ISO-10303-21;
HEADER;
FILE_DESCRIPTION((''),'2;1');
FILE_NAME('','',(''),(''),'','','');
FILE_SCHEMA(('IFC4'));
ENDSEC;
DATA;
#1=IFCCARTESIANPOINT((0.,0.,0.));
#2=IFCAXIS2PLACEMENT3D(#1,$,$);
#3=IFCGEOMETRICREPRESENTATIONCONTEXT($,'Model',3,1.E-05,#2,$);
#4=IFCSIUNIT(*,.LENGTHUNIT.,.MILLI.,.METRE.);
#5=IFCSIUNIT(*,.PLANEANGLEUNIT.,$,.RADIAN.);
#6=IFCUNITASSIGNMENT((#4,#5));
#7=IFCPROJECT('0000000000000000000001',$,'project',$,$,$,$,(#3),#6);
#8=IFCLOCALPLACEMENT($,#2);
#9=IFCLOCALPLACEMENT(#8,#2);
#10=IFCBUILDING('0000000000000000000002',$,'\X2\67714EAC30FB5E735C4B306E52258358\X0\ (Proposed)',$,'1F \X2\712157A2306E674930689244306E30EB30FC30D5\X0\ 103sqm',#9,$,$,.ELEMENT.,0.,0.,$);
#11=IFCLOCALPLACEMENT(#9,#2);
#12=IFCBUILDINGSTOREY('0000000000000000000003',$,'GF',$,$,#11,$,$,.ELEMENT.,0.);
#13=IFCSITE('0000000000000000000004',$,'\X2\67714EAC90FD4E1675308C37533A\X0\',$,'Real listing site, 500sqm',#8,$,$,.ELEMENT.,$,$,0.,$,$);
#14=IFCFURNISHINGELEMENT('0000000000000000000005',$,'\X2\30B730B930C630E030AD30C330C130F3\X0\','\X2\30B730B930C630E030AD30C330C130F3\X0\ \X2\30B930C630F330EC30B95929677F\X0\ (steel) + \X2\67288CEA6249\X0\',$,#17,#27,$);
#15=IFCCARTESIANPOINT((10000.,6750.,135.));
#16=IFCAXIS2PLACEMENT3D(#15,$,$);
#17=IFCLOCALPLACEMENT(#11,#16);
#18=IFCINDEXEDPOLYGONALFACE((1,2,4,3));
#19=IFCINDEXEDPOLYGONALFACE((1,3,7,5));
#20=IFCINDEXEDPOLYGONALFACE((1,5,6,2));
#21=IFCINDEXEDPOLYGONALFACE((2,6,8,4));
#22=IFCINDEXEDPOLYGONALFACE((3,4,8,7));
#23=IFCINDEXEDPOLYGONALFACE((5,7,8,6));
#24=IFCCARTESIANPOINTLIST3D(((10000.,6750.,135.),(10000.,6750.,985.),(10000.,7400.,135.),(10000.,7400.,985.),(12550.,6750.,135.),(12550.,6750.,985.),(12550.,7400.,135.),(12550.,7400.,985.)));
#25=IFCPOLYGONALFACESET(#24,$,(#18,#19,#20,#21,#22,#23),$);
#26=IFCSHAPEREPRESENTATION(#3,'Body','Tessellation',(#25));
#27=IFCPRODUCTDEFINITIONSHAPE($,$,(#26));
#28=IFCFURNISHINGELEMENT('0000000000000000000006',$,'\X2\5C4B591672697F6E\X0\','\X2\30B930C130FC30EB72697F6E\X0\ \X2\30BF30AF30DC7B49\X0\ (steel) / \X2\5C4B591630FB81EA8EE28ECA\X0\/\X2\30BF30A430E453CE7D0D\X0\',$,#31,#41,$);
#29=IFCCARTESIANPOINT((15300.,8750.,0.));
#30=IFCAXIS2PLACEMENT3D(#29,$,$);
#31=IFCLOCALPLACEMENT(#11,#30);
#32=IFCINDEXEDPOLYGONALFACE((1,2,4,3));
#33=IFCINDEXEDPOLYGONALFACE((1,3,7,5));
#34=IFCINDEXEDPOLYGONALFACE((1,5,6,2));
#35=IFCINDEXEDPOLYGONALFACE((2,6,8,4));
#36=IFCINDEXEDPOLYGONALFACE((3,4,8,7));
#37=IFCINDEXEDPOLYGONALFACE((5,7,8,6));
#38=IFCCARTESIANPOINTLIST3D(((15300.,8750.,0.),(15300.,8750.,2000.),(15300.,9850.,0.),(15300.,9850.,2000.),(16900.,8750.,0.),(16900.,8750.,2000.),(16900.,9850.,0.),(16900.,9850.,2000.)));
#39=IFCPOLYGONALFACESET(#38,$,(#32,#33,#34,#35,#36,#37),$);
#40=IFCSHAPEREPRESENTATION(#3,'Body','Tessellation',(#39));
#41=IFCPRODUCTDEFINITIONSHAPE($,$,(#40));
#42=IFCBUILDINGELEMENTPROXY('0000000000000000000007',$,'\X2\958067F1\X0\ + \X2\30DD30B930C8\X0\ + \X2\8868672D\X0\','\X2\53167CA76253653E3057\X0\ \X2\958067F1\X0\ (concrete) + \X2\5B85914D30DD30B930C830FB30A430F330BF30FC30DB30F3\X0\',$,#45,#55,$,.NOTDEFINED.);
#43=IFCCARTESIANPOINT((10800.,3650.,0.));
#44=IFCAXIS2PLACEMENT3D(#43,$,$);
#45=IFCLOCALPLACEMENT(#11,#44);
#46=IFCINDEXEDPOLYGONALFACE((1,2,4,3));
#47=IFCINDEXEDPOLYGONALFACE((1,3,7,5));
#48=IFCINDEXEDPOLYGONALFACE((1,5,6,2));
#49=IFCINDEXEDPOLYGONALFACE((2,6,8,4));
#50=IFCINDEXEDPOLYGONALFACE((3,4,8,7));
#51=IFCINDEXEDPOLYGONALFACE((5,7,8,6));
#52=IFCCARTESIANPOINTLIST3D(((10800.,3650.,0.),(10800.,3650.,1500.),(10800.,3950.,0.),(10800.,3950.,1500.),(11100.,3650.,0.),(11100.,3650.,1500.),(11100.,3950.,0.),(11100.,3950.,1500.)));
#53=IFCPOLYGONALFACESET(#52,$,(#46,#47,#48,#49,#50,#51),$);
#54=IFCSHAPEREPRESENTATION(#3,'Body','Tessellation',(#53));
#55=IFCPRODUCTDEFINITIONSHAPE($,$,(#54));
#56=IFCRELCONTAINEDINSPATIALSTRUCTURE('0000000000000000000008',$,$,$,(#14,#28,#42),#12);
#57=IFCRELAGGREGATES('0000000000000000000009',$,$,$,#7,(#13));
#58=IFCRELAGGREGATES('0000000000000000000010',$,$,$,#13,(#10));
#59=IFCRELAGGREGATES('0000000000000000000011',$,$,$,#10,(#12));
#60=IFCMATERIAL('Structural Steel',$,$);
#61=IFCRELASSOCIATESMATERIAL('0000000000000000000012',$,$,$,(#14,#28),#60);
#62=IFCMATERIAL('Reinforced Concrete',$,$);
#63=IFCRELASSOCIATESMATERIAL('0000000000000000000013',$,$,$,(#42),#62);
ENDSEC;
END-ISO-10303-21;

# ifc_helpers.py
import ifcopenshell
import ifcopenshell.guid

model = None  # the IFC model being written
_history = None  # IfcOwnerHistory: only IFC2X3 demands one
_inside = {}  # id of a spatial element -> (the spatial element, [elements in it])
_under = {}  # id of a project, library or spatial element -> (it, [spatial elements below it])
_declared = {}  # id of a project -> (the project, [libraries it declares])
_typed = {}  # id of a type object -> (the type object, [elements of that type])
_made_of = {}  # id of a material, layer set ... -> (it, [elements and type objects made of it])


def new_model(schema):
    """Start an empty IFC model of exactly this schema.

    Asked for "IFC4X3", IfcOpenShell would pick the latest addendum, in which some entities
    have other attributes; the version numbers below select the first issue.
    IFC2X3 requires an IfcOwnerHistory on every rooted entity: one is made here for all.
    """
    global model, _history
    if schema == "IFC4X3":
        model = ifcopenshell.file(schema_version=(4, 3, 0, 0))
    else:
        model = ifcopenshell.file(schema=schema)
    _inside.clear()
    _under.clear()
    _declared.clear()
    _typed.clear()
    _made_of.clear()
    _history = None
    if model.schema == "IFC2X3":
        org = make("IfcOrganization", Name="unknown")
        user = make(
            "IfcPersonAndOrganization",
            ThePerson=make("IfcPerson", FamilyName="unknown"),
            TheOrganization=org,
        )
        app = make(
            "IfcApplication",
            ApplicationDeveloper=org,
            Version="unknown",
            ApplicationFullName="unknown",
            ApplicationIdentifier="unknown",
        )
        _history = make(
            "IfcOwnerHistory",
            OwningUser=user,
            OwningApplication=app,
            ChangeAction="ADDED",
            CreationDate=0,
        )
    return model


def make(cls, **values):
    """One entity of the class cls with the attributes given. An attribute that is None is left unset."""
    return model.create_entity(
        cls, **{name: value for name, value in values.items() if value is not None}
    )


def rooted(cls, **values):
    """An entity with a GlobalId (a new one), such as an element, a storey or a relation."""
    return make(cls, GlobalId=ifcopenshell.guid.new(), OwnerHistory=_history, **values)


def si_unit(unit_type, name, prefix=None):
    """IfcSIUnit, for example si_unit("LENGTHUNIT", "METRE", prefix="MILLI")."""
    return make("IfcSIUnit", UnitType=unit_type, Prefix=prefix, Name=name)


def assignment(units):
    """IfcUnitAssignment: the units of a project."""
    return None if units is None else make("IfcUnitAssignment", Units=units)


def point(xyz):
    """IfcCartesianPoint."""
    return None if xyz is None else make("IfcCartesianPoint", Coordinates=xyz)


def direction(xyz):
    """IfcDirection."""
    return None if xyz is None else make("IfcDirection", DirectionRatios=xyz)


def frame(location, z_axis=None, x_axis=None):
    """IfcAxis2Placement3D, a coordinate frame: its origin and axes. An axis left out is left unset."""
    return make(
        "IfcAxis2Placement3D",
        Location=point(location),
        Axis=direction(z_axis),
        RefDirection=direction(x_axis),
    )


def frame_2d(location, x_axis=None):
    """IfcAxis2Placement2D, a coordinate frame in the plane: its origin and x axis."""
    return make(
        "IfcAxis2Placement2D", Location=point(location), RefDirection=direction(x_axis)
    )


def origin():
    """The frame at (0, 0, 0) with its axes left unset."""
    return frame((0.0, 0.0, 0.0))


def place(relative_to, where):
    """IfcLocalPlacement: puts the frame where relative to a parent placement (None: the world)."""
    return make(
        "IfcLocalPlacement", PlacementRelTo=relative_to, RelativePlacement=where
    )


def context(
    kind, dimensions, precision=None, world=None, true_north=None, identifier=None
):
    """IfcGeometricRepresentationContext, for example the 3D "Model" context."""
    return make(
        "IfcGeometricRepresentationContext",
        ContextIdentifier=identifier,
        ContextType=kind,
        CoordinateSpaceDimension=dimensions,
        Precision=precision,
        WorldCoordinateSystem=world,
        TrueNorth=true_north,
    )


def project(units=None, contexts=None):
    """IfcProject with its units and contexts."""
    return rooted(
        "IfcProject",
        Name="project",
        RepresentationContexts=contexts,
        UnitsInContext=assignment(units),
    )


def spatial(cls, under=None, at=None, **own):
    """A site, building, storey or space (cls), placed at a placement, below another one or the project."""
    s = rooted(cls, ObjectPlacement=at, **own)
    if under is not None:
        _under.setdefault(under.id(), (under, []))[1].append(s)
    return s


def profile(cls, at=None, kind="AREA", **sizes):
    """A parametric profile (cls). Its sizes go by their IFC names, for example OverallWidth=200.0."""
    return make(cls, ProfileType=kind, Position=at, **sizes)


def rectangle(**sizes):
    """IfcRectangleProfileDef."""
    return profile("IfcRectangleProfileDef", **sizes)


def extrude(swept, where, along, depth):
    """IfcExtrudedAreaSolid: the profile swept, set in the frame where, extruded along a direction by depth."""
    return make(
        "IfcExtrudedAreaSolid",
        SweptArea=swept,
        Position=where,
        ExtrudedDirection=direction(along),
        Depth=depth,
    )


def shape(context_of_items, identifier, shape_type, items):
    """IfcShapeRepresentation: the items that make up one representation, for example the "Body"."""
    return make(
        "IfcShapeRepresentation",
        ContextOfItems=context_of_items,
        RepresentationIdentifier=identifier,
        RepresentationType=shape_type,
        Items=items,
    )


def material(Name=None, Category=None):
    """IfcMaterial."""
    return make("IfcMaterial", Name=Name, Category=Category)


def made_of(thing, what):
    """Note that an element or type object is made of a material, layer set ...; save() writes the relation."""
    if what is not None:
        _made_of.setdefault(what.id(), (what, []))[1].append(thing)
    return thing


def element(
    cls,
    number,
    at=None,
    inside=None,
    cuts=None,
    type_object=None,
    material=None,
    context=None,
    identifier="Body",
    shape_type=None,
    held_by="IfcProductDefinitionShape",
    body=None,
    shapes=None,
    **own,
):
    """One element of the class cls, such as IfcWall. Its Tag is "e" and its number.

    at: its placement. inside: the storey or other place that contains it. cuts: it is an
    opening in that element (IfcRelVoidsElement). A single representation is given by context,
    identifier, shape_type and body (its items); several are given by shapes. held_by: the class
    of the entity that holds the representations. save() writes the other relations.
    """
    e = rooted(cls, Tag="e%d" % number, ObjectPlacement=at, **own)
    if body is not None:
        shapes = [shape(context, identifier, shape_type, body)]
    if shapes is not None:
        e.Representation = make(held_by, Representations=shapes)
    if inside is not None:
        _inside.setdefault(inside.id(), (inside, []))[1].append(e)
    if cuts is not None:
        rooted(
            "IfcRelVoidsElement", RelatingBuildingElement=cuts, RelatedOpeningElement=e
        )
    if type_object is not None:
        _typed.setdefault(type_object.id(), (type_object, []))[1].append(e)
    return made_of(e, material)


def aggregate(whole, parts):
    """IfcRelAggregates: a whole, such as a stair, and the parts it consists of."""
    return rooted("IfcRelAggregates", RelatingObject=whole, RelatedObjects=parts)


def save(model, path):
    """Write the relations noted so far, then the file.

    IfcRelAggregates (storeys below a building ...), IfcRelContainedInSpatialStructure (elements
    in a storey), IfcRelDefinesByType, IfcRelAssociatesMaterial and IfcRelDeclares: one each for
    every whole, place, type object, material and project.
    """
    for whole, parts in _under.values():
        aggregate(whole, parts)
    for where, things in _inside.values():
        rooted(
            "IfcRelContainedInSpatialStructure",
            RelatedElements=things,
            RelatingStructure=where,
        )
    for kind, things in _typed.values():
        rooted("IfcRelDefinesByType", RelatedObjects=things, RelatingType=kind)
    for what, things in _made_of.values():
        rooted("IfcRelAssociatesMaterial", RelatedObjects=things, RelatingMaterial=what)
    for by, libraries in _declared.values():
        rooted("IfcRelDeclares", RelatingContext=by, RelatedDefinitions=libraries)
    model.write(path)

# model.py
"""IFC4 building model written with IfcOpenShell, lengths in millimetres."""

from ifc_helpers import new_model, si_unit, frame, frame_2d, origin, place, context, project, spatial, rectangle, extrude, material, element, save


model = new_model("IFC4")

# Units and contexts
model_context = context("Model", 3, precision=1e-05, world=origin())
ifc_project = project(units=[si_unit("LENGTHUNIT", "METRE", prefix="MILLI"), si_unit("PLANEANGLEUNIT", "RADIAN")], contexts=[model_context])

# Site, building, storey
site_placement = place(None, origin())
site = spatial("IfcSite", under=ifc_project, at=site_placement, Name="東京都世田谷区", ObjectType="Real listing site, 500sqm", CompositionType="ELEMENT", RefElevation=0.0)
building_placement = place(site_placement, origin())
building = spatial("IfcBuilding", under=site, at=building_placement, Name="東京・平屋の別荘 (Proposed)", ObjectType="1F 無垢の杉と鉄のルーフ 103sqm", CompositionType="ELEMENT", ElevationOfRefHeight=0.0, ElevationOfTerrain=0.0)
storey_placement = place(building_placement, origin())
storey = spatial("IfcBuildingStorey", under=building, at=storey_placement, Name="GF", CompositionType="ELEMENT", Elevation=0.0)

# Shared definitions
ifc_material_1 = material(Name="Reinforced Concrete")

# Shared definitions
ifc_material_2 = material(Name="Structural Steel")

# Furnishing elements
furnishing_1_placement = place(storey_placement, frame((10000.0, 6750.0, 135.0)))
element("IfcFurnishingElement", 1, at=furnishing_1_placement, inside=storey, material=ifc_material_2, Name="システムキッチン", Description="システムキッチン ステンレス天板 (steel) + 木質扉", context=model_context, shape_type="SweptSolid", body=[
    extrude(rectangle(XDim=2550.0, YDim=650.0, at=frame_2d((1275.0, 325.0))), frame((10000.0, 6750.0, 135.0)), (0.0, 0.0, 1.0), 850.0),
])
furnishing_2_placement = place(storey_placement, frame((15300.0, 8750.0, 0.0)))
element("IfcFurnishingElement", 2, at=furnishing_2_placement, inside=storey, material=ifc_material_2, Name="屋外物置", Description="スチール物置 タクボ等 (steel) / 屋外・自転車/タイヤ収納", context=model_context, shape_type="SweptSolid", body=[
    extrude(rectangle(XDim=1600.0, YDim=1100.0, at=frame_2d((800.0, 550.0))), frame((15300.0, 8750.0, 0.0)), (0.0, 0.0, 1.0), 2000.0),
])

# Building element proxy
proxy_placement = place(storey_placement, frame((10800.0, 3650.0, 0.0)))
element("IfcBuildingElementProxy", 3, at=proxy_placement, inside=storey, material=ifc_material_1, Name="門柱 + ポスト + 表札", Description="化粧打放し 門柱 (concrete) + 宅配ポスト・インターホン", PredefinedType="NOTDEFINED", context=model_context, shape_type="SweptSolid", body=[
    extrude(rectangle(XDim=300.0, YDim=300.0, at=frame_2d((150.0, 150.0))), frame((10800.0, 3650.0, 0.0)), (0.0, 0.0, 1.0), 1500.0),
])

save(model, "model.ifc")
